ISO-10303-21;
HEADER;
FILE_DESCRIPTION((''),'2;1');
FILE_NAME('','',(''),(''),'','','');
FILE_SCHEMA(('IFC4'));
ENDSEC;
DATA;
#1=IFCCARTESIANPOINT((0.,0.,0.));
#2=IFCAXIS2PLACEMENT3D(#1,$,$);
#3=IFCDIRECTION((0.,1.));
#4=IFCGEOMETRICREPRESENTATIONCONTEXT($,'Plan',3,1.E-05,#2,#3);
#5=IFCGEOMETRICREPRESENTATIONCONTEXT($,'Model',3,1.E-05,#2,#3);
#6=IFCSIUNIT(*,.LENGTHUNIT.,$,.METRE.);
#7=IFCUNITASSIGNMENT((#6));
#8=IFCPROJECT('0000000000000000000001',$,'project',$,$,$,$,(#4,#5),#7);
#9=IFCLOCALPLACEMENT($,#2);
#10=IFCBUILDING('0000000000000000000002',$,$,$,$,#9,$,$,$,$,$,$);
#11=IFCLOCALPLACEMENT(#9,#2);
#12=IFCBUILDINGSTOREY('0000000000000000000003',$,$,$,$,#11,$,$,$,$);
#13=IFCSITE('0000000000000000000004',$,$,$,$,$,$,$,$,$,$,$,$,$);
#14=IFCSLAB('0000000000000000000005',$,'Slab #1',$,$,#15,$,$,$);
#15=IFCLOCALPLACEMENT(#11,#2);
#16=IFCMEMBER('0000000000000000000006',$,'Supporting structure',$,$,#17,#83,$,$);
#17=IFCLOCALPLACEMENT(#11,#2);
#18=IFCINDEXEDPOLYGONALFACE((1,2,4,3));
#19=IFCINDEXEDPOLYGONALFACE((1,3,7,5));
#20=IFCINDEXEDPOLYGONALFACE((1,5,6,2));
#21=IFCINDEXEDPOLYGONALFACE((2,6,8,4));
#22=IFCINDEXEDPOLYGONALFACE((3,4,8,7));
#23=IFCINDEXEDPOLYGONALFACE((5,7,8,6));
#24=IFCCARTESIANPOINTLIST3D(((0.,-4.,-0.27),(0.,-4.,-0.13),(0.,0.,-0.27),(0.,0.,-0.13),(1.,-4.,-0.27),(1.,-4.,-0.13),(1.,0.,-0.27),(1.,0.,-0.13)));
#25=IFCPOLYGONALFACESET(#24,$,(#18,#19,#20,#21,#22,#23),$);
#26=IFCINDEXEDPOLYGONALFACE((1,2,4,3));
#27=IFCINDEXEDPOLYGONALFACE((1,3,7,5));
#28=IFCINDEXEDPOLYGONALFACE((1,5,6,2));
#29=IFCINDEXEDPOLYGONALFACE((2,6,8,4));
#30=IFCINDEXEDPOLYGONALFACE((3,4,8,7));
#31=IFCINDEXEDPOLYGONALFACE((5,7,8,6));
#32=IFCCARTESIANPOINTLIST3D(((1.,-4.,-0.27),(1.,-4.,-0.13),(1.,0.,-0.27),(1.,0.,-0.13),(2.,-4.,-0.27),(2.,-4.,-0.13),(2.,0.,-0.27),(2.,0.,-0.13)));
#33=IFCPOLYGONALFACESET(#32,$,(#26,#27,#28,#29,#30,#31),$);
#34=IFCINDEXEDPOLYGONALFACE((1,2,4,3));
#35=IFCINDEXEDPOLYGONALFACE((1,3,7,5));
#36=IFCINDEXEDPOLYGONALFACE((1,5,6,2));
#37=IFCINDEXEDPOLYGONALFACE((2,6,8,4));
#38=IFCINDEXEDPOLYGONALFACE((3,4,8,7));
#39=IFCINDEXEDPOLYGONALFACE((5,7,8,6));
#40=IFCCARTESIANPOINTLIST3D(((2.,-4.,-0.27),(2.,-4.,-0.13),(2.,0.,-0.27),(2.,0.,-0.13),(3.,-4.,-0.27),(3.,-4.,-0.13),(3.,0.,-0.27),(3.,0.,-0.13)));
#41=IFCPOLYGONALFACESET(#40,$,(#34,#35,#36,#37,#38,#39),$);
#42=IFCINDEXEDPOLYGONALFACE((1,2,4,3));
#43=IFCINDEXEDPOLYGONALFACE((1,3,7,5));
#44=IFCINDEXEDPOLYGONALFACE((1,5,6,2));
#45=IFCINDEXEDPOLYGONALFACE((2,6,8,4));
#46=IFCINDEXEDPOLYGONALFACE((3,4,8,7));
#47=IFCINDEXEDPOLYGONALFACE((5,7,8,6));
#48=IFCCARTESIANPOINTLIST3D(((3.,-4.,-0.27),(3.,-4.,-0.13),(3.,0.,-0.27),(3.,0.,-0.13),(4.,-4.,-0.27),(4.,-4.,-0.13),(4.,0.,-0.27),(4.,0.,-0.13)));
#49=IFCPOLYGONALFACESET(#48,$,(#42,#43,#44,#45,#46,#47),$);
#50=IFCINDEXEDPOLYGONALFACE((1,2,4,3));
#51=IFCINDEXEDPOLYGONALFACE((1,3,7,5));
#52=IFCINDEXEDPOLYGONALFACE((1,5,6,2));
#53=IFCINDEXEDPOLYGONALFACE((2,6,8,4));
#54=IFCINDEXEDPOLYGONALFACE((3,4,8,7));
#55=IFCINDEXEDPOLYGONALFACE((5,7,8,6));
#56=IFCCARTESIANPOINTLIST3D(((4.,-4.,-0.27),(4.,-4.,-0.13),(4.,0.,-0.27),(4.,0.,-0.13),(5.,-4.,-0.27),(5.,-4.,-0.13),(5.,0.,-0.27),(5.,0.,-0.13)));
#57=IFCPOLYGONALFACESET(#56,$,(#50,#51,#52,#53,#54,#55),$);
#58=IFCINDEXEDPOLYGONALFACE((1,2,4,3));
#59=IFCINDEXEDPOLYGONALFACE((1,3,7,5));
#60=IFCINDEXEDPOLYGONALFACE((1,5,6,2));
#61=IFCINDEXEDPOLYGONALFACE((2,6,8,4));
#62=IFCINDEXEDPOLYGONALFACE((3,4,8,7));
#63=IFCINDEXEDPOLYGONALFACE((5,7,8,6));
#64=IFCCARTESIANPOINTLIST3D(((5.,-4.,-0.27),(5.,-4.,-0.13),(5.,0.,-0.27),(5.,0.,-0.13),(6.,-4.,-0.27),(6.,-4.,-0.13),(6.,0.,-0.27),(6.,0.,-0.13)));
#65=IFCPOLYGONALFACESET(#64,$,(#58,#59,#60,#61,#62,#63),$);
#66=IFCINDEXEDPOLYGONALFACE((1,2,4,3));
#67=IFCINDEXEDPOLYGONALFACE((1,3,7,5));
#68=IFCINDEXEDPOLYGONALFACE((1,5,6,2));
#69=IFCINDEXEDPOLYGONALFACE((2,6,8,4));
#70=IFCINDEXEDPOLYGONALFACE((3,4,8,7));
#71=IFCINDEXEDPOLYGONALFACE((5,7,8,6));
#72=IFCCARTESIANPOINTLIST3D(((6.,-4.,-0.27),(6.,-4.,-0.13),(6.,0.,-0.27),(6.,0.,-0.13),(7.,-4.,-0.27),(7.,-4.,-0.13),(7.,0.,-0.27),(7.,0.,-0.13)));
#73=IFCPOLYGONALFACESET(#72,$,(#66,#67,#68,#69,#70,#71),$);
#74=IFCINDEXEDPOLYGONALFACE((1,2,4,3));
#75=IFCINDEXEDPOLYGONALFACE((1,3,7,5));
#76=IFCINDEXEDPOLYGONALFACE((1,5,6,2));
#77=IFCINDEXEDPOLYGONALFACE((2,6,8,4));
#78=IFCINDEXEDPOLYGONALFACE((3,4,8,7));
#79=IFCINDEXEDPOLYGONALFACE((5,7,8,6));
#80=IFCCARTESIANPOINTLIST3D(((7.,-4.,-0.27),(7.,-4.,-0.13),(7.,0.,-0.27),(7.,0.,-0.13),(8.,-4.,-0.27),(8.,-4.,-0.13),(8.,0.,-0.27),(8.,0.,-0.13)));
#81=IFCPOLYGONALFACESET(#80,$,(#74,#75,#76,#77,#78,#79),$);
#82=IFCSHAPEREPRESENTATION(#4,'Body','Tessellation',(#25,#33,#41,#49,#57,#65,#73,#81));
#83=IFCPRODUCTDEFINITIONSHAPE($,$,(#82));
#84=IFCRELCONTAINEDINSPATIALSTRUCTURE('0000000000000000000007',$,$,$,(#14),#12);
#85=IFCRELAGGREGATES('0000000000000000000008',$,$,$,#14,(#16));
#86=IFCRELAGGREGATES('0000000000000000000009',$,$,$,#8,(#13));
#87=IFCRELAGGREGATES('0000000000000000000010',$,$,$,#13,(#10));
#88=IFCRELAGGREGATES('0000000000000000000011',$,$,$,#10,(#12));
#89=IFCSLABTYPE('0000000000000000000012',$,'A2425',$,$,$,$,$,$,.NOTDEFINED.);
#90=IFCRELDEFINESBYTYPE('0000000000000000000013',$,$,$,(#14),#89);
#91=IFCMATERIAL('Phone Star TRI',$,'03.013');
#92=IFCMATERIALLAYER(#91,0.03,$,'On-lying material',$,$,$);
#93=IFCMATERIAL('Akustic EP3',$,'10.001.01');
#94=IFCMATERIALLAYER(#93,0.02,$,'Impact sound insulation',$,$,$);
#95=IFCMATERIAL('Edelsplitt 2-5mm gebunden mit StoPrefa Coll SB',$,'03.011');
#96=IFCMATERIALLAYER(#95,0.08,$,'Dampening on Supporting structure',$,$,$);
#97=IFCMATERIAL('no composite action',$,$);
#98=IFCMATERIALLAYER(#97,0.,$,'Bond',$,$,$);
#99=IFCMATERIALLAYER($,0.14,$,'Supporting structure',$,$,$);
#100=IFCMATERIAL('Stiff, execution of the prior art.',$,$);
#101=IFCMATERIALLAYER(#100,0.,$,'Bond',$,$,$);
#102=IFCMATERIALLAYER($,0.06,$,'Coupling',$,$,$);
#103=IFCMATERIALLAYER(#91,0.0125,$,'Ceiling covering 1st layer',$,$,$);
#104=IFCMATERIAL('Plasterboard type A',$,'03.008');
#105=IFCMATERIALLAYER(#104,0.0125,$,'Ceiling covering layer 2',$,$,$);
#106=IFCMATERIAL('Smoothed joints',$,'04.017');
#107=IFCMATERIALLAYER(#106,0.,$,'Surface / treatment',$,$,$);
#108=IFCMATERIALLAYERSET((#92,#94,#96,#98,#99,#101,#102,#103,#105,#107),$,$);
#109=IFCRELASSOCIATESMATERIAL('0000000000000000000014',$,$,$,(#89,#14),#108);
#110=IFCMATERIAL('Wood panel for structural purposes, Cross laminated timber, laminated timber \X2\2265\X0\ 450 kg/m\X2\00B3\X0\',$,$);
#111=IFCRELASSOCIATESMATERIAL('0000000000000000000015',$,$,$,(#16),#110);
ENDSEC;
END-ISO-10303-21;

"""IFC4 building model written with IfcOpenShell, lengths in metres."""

from ifc_helpers import new_model, si_unit, direction, frame, frame_2d, origin, place, context, project, spatial, rectangle, extrude, material, layer, layer_set, type_object, element, aggregate, save


model = new_model("IFC4")

# Units and contexts
plan_context = context("Plan", 3, precision=1e-05, world=origin(), true_north=direction((0.0, 1.0)))
model_context = context("Model", 3, precision=1e-05, world=origin(), true_north=direction((0.0, 1.0)))
ifc_project = project(units=[si_unit("LENGTHUNIT", "METRE")], contexts=[plan_context, model_context])

# Site, building, storey
site = spatial("IfcSite", under=ifc_project)
building_placement = place(None, origin())
building = spatial("IfcBuilding", under=site, at=building_placement)
storey_placement = place(building_placement, origin())
storey = spatial("IfcBuildingStorey", under=building, at=storey_placement)

# Slab, member
ifc_material_1 = material(Name="Phone Star TRI", Category="03.013")
ifc_layer_1 = layer(ifc_material_1, 0.03, Name="On-lying material")
ifc_material_2 = material(Name="Akustic EP3", Category="10.001.01")
ifc_layer_2 = layer(ifc_material_2, 0.02, Name="Impact sound insulation")
ifc_material_3 = material(Name="Edelsplitt 2-5mm gebunden mit StoPrefa Coll SB", Category="03.011")
ifc_layer_3 = layer(ifc_material_3, 0.08, Name="Dampening on Supporting structure")
ifc_material_4 = material(Name="no composite action")
ifc_layer_4 = layer(ifc_material_4, 0.0, Name="Bond")
ifc_layer_5 = layer(None, 0.14, Name="Supporting structure")
ifc_material_5 = material(Name="Stiff, execution of the prior art.")
ifc_layer_6 = layer(ifc_material_5, 0.0, Name="Bond")
ifc_layer_7 = layer(None, 0.06, Name="Coupling")
ifc_layer_8 = layer(ifc_material_1, 0.0125, Name="Ceiling covering 1st layer")
ifc_material_6 = material(Name="Plasterboard type A", Category="03.008")
ifc_layer_9 = layer(ifc_material_6, 0.0125, Name="Ceiling covering layer 2")
ifc_material_7 = material(Name="Smoothed joints", Category="04.017")
ifc_layer_10 = layer(ifc_material_7, 0.0, Name="Surface / treatment")
ifc_layer_set = layer_set([ifc_layer_1, ifc_layer_2, ifc_layer_3, ifc_layer_4, ifc_layer_5, ifc_layer_6, ifc_layer_7, ifc_layer_8, ifc_layer_9, ifc_layer_10])
slab_type = type_object("IfcSlabType", Name="A2425", PredefinedType="NOTDEFINED", material=ifc_layer_set)
slab_placement = place(None, frame((0.0, 0.0, 0.0), z_axis=(0.0, 0.0, -1.0), x_axis=(1.0, 0.0, 0.0)))
slab = element("IfcSlab", 1, at=slab_placement, inside=storey, type_object=slab_type, material=ifc_layer_set, Name="Slab #1")
ifc_material_8 = material(Name="Wood panel for structural purposes, Cross laminated timber, laminated timber ≥ 450 kg/m³")
member_1_placement = place(slab_placement, origin())
member_1 = element("IfcMember", 2, at=member_1_placement, material=ifc_material_8, Name="Supporting structure", context=plan_context, shape_type="SweptSolid", body=[
    extrude(rectangle(XDim=1.0, YDim=0.14, at=frame_2d((0.5, 0.07), x_axis=(1.0, 0.0))), frame((0.0, 4.0, 0.13), z_axis=(0.0, -1.0, 0.0), x_axis=(1.0, 0.0, 0.0)), (0.0, 0.0, 1.0), 4.0),
    extrude(rectangle(XDim=1.0, YDim=0.14, at=frame_2d((0.5, 0.07), x_axis=(1.0, 0.0))), frame((1.0, 4.0, 0.13), z_axis=(0.0, -1.0, 0.0), x_axis=(1.0, 0.0, 0.0)), (0.0, 0.0, 1.0), 4.0),
    extrude(rectangle(XDim=1.0, YDim=0.14, at=frame_2d((0.5, 0.07), x_axis=(1.0, 0.0))), frame((2.0, 4.0, 0.13), z_axis=(0.0, -1.0, 0.0), x_axis=(1.0, 0.0, 0.0)), (0.0, 0.0, 1.0), 4.0),
    extrude(rectangle(XDim=1.0, YDim=0.14, at=frame_2d((0.5, 0.07), x_axis=(1.0, 0.0))), frame((3.0, 4.0, 0.13), z_axis=(0.0, -1.0, 0.0), x_axis=(1.0, 0.0, 0.0)), (0.0, 0.0, 1.0), 4.0),
    extrude(rectangle(XDim=1.0, YDim=0.14, at=frame_2d((0.5, 0.07), x_axis=(1.0, 0.0))), frame((4.0, 4.0, 0.13), z_axis=(0.0, -1.0, 0.0), x_axis=(1.0, 0.0, 0.0)), (0.0, 0.0, 1.0), 4.0),
    extrude(rectangle(XDim=1.0, YDim=0.14, at=frame_2d((0.5, 0.07), x_axis=(1.0, 0.0))), frame((5.0, 4.0, 0.13), z_axis=(0.0, -1.0, 0.0), x_axis=(1.0, 0.0, 0.0)), (0.0, 0.0, 1.0), 4.0),
    extrude(rectangle(XDim=1.0, YDim=0.14, at=frame_2d((0.5, 0.07), x_axis=(1.0, 0.0))), frame((6.0, 4.0, 0.13), z_axis=(0.0, -1.0, 0.0), x_axis=(1.0, 0.0, 0.0)), (0.0, 0.0, 1.0), 4.0),
    extrude(rectangle(XDim=1.0, YDim=0.14, at=frame_2d((0.5, 0.07), x_axis=(1.0, 0.0))), frame((7.0, 4.0, 0.13), z_axis=(0.0, -1.0, 0.0), x_axis=(1.0, 0.0, 0.0)), (0.0, 0.0, 1.0), 4.0),
])
aggregate(slab, [member_1])

save(model, "model.ifc")
